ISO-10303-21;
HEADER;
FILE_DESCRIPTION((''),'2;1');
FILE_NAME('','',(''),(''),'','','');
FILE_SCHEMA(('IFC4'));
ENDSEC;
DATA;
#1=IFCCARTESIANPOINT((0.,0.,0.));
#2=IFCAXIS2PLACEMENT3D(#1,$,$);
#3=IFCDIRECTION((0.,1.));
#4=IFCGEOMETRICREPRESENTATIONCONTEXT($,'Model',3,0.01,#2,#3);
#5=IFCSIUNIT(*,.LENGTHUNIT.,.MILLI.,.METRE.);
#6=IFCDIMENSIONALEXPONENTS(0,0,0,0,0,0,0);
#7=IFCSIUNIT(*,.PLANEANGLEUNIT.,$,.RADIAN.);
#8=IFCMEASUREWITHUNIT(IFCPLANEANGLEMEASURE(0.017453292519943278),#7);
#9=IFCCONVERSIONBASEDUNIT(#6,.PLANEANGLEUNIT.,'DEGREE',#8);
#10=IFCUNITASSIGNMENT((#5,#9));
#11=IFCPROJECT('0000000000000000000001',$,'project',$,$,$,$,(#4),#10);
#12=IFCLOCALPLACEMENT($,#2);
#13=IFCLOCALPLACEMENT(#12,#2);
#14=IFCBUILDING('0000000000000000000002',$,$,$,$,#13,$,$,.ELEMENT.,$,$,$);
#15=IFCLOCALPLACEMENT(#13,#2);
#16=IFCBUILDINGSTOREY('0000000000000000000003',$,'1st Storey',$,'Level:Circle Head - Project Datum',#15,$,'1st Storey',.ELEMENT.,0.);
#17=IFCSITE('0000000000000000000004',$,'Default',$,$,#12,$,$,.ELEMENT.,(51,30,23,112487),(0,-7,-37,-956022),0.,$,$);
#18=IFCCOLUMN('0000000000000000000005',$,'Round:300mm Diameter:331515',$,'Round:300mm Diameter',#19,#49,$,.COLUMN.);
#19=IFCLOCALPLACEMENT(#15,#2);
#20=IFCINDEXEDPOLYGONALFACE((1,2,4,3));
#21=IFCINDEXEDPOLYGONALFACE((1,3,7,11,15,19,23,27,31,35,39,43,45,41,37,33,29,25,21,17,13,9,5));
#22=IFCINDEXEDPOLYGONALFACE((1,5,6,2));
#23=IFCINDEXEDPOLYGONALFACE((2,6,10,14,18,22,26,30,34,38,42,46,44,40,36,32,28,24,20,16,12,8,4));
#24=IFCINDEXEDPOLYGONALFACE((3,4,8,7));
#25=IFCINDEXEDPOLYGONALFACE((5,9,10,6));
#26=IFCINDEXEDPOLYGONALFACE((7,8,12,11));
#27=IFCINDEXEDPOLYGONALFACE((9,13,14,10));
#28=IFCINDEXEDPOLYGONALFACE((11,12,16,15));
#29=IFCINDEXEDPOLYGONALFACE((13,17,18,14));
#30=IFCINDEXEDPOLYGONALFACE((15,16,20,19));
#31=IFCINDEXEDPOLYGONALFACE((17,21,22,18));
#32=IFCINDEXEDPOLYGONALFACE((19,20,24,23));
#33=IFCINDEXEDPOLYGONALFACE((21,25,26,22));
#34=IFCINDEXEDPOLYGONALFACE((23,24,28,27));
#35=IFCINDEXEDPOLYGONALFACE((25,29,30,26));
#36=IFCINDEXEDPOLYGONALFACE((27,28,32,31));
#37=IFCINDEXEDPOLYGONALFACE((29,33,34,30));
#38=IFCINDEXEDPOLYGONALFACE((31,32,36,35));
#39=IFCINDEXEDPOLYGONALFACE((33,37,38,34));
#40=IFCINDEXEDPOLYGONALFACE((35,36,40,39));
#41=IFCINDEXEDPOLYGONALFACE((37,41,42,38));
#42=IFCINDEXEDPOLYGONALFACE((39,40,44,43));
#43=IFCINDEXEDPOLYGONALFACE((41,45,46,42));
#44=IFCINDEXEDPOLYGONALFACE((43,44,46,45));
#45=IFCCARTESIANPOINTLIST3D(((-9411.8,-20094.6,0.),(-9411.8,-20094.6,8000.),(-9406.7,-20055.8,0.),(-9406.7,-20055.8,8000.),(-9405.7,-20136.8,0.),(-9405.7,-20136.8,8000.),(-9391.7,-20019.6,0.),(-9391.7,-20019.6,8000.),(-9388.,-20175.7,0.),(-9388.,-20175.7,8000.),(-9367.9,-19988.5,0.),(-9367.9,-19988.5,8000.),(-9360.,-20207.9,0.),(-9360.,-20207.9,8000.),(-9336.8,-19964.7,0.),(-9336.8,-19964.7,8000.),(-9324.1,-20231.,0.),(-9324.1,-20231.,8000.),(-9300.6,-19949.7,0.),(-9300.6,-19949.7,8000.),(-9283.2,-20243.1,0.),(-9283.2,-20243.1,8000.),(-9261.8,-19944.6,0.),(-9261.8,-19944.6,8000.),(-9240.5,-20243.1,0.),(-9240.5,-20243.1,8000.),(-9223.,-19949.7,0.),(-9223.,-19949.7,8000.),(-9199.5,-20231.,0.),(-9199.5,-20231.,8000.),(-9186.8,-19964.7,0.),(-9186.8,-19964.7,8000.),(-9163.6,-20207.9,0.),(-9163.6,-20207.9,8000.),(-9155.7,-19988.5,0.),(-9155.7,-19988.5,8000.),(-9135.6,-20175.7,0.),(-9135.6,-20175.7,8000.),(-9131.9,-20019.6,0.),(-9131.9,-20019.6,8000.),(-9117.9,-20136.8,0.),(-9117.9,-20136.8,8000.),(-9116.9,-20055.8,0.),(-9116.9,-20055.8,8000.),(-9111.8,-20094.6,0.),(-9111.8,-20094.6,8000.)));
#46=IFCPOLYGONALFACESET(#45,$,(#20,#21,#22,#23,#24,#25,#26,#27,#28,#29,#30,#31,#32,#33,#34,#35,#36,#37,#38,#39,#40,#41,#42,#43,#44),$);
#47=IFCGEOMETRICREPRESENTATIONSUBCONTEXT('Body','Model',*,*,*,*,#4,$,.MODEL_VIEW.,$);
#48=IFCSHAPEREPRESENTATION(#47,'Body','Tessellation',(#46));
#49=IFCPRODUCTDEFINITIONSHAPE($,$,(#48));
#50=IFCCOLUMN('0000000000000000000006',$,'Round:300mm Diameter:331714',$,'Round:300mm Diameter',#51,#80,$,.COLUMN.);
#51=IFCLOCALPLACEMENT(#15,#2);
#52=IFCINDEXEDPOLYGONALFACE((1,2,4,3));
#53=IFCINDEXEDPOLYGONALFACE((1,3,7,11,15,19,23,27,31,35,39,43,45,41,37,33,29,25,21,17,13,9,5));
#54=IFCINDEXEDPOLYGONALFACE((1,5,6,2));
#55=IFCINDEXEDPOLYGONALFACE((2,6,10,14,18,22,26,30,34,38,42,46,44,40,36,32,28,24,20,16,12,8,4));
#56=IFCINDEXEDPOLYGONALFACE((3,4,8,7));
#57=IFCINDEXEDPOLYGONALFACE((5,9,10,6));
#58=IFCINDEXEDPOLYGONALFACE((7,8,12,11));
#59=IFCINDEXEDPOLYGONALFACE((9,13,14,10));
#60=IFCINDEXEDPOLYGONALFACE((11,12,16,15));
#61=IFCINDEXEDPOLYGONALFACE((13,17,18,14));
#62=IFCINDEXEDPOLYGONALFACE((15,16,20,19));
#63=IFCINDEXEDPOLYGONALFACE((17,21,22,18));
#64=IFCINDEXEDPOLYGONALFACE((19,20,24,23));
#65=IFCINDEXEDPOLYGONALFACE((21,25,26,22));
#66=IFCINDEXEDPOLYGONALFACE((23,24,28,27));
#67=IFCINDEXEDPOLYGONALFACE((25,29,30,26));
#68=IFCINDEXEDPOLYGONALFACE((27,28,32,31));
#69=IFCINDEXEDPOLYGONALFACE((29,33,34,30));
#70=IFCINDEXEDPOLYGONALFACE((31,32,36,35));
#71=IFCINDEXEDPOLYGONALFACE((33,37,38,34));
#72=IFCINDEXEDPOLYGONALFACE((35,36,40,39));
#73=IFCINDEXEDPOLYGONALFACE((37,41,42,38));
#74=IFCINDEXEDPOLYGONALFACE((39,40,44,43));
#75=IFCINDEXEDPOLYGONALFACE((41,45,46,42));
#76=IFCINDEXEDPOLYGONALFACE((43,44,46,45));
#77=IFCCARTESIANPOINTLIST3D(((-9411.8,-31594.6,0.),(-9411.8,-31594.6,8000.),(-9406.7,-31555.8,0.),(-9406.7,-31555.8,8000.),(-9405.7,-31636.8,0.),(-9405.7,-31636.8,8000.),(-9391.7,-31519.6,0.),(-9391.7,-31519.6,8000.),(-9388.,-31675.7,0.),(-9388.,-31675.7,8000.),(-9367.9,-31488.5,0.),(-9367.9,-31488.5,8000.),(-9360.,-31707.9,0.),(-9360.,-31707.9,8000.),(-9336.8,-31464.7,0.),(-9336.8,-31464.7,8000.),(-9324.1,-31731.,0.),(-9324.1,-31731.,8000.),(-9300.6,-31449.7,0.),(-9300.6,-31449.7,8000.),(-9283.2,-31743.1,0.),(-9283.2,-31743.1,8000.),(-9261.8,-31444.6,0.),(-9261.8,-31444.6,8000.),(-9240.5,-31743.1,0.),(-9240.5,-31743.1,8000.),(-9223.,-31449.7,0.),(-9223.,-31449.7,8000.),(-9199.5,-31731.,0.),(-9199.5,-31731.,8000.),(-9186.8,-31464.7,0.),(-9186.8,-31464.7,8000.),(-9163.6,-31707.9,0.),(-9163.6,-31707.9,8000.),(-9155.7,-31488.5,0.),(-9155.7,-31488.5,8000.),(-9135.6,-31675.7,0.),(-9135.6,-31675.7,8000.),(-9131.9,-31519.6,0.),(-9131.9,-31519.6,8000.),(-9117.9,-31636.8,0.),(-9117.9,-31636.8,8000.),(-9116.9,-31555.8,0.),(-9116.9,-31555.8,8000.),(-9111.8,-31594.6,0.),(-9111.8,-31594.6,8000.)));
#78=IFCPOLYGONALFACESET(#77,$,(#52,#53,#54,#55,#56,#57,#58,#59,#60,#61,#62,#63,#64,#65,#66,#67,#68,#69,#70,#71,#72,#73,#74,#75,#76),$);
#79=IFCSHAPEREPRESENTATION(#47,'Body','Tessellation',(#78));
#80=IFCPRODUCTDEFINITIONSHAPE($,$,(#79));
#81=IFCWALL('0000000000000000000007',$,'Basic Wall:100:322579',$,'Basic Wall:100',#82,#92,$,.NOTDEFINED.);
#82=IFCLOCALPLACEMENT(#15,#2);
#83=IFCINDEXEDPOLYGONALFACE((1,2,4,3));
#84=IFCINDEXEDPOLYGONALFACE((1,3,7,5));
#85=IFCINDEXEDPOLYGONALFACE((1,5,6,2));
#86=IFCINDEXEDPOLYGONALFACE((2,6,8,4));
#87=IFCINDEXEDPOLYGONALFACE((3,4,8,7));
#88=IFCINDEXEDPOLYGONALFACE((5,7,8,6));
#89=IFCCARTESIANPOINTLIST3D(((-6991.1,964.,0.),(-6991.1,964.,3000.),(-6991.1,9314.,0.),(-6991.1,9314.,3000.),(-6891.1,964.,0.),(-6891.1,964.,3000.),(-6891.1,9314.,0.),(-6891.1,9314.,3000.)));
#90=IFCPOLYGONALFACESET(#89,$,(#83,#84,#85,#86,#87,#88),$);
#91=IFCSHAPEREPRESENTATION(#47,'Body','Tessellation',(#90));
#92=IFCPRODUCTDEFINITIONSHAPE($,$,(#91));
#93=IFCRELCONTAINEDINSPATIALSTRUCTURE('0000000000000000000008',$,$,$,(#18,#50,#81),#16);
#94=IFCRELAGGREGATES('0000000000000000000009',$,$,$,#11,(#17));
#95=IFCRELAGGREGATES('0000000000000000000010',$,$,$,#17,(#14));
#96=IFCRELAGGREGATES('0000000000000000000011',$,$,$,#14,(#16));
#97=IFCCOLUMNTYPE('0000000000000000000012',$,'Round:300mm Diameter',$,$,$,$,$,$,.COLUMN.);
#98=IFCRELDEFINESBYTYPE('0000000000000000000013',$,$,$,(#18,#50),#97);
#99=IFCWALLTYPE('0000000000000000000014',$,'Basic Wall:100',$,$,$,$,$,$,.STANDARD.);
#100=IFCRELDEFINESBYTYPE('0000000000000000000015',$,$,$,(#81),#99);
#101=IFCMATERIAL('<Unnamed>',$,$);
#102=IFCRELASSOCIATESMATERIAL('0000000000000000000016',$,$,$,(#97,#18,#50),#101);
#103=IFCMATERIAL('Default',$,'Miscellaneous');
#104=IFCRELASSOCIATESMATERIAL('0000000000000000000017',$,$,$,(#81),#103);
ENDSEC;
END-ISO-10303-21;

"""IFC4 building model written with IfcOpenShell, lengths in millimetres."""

from ifc_helpers import new_model, entity, si_unit, converted_unit, direction, frame, origin, place, context, subcontext, project, spatial, arc, indexed_curve, outline, extrude, source, transform, mapped, material, type_object, type_shapes, element, save


model = new_model("IFC4")

# Units and contexts
model_context = context("Model", 3, precision=0.01, world=origin(), true_north=direction((0.0, 1.0)))
body_context = subcontext(model_context, "Body", "Model", "MODEL_VIEW")
ifc_project = project(units=[si_unit("LENGTHUNIT", "METRE", prefix="MILLI"), converted_unit("PLANEANGLEUNIT", "DEGREE", entity("IfcPlaneAngleMeasure", 0.017453292519943278), si_unit("PLANEANGLEUNIT", "RADIAN"), dimensions=[0, 0, 0, 0, 0, 0, 0])], contexts=[model_context])

# Site, building, storey
site_placement = place(None, origin())
site = spatial("IfcSite", under=ifc_project, at=site_placement, Name="Default", CompositionType="ELEMENT", RefLatitude=(51, 30, 23, 112487), RefLongitude=(0, -7, -37, -956022), RefElevation=0.0)
building_placement = place(site_placement, origin())
building = spatial("IfcBuilding", under=site, at=building_placement, CompositionType="ELEMENT")
storey_placement = place(building_placement, origin())
storey = spatial("IfcBuildingStorey", under=building, at=storey_placement, Name="1st Storey", ObjectType="Level:Circle Head - Project Datum", LongName="1st Storey", CompositionType="ELEMENT", Elevation=0.0)

# Columns
ifc_material_1 = material(Name="<Unnamed>")
column_type = type_object("IfcColumnType", Name="Round:300mm Diameter", PredefinedType="COLUMN", material=ifc_material_1)
shared_shape = source(origin(), body_context, "Body", "SweptSolid", [
    extrude(outline(indexed_curve([(150.0, -50.0), (106.1, 56.1), (0.0, 100.0), (-106.1, 56.1), (-150.0, -50.0), (0.0, -200.0)], segments=[arc(1, 2, 3), arc(3, 4, 5), arc(5, 6, 1)], self_intersect=False)), frame((0.0, 50.0, 0.0)), (0.0, 0.0, 1.0), 8000.0),
])
type_shapes(column_type, [shared_shape])
for number, where, name in (
    (1, (-9261.8, -20094.6, 0.0), "Round:300mm Diameter:331515"),
    (2, (-9261.8, -31594.6, 0.0), "Round:300mm Diameter:331714"),
):
    element("IfcColumn", number, at=place(storey_placement, frame(where)), inside=storey, type_object=column_type, material=ifc_material_1, Name=name, ObjectType="Round:300mm Diameter", PredefinedType="COLUMN", context=body_context, shape_type="MappedRepresentation", body=[
        mapped(shared_shape, transform((0.0, 0.0, 0.0), scale=1.0)),
    ])

# Wall
ifc_material_2 = material(Name="Default", Category="Miscellaneous")
wall_type = type_object("IfcWallType", Name="Basic Wall:100", PredefinedType="STANDARD")
wall_placement = place(storey_placement, frame((-6941.1, 9314.0, 0.0), z_axis=(0.0, 0.0, 1.0), x_axis=(0.0, -1.0, 0.0)))
element("IfcWall", 3, at=wall_placement, inside=storey, type_object=wall_type, material=ifc_material_2, Name="Basic Wall:100:322579", ObjectType="Basic Wall:100", PredefinedType="NOTDEFINED", context=body_context, shape_type="SweptSolid", body=[
    extrude(outline(indexed_curve([(8350.0, 50.0), (0.0, 50.0), (0.0, -50.0), (8350.0, -50.0), (8350.0, 50.0)], self_intersect=False)), origin(), (0.0, 0.0, 1.0), 3000.0),
])

save(model, "model.ifc")
